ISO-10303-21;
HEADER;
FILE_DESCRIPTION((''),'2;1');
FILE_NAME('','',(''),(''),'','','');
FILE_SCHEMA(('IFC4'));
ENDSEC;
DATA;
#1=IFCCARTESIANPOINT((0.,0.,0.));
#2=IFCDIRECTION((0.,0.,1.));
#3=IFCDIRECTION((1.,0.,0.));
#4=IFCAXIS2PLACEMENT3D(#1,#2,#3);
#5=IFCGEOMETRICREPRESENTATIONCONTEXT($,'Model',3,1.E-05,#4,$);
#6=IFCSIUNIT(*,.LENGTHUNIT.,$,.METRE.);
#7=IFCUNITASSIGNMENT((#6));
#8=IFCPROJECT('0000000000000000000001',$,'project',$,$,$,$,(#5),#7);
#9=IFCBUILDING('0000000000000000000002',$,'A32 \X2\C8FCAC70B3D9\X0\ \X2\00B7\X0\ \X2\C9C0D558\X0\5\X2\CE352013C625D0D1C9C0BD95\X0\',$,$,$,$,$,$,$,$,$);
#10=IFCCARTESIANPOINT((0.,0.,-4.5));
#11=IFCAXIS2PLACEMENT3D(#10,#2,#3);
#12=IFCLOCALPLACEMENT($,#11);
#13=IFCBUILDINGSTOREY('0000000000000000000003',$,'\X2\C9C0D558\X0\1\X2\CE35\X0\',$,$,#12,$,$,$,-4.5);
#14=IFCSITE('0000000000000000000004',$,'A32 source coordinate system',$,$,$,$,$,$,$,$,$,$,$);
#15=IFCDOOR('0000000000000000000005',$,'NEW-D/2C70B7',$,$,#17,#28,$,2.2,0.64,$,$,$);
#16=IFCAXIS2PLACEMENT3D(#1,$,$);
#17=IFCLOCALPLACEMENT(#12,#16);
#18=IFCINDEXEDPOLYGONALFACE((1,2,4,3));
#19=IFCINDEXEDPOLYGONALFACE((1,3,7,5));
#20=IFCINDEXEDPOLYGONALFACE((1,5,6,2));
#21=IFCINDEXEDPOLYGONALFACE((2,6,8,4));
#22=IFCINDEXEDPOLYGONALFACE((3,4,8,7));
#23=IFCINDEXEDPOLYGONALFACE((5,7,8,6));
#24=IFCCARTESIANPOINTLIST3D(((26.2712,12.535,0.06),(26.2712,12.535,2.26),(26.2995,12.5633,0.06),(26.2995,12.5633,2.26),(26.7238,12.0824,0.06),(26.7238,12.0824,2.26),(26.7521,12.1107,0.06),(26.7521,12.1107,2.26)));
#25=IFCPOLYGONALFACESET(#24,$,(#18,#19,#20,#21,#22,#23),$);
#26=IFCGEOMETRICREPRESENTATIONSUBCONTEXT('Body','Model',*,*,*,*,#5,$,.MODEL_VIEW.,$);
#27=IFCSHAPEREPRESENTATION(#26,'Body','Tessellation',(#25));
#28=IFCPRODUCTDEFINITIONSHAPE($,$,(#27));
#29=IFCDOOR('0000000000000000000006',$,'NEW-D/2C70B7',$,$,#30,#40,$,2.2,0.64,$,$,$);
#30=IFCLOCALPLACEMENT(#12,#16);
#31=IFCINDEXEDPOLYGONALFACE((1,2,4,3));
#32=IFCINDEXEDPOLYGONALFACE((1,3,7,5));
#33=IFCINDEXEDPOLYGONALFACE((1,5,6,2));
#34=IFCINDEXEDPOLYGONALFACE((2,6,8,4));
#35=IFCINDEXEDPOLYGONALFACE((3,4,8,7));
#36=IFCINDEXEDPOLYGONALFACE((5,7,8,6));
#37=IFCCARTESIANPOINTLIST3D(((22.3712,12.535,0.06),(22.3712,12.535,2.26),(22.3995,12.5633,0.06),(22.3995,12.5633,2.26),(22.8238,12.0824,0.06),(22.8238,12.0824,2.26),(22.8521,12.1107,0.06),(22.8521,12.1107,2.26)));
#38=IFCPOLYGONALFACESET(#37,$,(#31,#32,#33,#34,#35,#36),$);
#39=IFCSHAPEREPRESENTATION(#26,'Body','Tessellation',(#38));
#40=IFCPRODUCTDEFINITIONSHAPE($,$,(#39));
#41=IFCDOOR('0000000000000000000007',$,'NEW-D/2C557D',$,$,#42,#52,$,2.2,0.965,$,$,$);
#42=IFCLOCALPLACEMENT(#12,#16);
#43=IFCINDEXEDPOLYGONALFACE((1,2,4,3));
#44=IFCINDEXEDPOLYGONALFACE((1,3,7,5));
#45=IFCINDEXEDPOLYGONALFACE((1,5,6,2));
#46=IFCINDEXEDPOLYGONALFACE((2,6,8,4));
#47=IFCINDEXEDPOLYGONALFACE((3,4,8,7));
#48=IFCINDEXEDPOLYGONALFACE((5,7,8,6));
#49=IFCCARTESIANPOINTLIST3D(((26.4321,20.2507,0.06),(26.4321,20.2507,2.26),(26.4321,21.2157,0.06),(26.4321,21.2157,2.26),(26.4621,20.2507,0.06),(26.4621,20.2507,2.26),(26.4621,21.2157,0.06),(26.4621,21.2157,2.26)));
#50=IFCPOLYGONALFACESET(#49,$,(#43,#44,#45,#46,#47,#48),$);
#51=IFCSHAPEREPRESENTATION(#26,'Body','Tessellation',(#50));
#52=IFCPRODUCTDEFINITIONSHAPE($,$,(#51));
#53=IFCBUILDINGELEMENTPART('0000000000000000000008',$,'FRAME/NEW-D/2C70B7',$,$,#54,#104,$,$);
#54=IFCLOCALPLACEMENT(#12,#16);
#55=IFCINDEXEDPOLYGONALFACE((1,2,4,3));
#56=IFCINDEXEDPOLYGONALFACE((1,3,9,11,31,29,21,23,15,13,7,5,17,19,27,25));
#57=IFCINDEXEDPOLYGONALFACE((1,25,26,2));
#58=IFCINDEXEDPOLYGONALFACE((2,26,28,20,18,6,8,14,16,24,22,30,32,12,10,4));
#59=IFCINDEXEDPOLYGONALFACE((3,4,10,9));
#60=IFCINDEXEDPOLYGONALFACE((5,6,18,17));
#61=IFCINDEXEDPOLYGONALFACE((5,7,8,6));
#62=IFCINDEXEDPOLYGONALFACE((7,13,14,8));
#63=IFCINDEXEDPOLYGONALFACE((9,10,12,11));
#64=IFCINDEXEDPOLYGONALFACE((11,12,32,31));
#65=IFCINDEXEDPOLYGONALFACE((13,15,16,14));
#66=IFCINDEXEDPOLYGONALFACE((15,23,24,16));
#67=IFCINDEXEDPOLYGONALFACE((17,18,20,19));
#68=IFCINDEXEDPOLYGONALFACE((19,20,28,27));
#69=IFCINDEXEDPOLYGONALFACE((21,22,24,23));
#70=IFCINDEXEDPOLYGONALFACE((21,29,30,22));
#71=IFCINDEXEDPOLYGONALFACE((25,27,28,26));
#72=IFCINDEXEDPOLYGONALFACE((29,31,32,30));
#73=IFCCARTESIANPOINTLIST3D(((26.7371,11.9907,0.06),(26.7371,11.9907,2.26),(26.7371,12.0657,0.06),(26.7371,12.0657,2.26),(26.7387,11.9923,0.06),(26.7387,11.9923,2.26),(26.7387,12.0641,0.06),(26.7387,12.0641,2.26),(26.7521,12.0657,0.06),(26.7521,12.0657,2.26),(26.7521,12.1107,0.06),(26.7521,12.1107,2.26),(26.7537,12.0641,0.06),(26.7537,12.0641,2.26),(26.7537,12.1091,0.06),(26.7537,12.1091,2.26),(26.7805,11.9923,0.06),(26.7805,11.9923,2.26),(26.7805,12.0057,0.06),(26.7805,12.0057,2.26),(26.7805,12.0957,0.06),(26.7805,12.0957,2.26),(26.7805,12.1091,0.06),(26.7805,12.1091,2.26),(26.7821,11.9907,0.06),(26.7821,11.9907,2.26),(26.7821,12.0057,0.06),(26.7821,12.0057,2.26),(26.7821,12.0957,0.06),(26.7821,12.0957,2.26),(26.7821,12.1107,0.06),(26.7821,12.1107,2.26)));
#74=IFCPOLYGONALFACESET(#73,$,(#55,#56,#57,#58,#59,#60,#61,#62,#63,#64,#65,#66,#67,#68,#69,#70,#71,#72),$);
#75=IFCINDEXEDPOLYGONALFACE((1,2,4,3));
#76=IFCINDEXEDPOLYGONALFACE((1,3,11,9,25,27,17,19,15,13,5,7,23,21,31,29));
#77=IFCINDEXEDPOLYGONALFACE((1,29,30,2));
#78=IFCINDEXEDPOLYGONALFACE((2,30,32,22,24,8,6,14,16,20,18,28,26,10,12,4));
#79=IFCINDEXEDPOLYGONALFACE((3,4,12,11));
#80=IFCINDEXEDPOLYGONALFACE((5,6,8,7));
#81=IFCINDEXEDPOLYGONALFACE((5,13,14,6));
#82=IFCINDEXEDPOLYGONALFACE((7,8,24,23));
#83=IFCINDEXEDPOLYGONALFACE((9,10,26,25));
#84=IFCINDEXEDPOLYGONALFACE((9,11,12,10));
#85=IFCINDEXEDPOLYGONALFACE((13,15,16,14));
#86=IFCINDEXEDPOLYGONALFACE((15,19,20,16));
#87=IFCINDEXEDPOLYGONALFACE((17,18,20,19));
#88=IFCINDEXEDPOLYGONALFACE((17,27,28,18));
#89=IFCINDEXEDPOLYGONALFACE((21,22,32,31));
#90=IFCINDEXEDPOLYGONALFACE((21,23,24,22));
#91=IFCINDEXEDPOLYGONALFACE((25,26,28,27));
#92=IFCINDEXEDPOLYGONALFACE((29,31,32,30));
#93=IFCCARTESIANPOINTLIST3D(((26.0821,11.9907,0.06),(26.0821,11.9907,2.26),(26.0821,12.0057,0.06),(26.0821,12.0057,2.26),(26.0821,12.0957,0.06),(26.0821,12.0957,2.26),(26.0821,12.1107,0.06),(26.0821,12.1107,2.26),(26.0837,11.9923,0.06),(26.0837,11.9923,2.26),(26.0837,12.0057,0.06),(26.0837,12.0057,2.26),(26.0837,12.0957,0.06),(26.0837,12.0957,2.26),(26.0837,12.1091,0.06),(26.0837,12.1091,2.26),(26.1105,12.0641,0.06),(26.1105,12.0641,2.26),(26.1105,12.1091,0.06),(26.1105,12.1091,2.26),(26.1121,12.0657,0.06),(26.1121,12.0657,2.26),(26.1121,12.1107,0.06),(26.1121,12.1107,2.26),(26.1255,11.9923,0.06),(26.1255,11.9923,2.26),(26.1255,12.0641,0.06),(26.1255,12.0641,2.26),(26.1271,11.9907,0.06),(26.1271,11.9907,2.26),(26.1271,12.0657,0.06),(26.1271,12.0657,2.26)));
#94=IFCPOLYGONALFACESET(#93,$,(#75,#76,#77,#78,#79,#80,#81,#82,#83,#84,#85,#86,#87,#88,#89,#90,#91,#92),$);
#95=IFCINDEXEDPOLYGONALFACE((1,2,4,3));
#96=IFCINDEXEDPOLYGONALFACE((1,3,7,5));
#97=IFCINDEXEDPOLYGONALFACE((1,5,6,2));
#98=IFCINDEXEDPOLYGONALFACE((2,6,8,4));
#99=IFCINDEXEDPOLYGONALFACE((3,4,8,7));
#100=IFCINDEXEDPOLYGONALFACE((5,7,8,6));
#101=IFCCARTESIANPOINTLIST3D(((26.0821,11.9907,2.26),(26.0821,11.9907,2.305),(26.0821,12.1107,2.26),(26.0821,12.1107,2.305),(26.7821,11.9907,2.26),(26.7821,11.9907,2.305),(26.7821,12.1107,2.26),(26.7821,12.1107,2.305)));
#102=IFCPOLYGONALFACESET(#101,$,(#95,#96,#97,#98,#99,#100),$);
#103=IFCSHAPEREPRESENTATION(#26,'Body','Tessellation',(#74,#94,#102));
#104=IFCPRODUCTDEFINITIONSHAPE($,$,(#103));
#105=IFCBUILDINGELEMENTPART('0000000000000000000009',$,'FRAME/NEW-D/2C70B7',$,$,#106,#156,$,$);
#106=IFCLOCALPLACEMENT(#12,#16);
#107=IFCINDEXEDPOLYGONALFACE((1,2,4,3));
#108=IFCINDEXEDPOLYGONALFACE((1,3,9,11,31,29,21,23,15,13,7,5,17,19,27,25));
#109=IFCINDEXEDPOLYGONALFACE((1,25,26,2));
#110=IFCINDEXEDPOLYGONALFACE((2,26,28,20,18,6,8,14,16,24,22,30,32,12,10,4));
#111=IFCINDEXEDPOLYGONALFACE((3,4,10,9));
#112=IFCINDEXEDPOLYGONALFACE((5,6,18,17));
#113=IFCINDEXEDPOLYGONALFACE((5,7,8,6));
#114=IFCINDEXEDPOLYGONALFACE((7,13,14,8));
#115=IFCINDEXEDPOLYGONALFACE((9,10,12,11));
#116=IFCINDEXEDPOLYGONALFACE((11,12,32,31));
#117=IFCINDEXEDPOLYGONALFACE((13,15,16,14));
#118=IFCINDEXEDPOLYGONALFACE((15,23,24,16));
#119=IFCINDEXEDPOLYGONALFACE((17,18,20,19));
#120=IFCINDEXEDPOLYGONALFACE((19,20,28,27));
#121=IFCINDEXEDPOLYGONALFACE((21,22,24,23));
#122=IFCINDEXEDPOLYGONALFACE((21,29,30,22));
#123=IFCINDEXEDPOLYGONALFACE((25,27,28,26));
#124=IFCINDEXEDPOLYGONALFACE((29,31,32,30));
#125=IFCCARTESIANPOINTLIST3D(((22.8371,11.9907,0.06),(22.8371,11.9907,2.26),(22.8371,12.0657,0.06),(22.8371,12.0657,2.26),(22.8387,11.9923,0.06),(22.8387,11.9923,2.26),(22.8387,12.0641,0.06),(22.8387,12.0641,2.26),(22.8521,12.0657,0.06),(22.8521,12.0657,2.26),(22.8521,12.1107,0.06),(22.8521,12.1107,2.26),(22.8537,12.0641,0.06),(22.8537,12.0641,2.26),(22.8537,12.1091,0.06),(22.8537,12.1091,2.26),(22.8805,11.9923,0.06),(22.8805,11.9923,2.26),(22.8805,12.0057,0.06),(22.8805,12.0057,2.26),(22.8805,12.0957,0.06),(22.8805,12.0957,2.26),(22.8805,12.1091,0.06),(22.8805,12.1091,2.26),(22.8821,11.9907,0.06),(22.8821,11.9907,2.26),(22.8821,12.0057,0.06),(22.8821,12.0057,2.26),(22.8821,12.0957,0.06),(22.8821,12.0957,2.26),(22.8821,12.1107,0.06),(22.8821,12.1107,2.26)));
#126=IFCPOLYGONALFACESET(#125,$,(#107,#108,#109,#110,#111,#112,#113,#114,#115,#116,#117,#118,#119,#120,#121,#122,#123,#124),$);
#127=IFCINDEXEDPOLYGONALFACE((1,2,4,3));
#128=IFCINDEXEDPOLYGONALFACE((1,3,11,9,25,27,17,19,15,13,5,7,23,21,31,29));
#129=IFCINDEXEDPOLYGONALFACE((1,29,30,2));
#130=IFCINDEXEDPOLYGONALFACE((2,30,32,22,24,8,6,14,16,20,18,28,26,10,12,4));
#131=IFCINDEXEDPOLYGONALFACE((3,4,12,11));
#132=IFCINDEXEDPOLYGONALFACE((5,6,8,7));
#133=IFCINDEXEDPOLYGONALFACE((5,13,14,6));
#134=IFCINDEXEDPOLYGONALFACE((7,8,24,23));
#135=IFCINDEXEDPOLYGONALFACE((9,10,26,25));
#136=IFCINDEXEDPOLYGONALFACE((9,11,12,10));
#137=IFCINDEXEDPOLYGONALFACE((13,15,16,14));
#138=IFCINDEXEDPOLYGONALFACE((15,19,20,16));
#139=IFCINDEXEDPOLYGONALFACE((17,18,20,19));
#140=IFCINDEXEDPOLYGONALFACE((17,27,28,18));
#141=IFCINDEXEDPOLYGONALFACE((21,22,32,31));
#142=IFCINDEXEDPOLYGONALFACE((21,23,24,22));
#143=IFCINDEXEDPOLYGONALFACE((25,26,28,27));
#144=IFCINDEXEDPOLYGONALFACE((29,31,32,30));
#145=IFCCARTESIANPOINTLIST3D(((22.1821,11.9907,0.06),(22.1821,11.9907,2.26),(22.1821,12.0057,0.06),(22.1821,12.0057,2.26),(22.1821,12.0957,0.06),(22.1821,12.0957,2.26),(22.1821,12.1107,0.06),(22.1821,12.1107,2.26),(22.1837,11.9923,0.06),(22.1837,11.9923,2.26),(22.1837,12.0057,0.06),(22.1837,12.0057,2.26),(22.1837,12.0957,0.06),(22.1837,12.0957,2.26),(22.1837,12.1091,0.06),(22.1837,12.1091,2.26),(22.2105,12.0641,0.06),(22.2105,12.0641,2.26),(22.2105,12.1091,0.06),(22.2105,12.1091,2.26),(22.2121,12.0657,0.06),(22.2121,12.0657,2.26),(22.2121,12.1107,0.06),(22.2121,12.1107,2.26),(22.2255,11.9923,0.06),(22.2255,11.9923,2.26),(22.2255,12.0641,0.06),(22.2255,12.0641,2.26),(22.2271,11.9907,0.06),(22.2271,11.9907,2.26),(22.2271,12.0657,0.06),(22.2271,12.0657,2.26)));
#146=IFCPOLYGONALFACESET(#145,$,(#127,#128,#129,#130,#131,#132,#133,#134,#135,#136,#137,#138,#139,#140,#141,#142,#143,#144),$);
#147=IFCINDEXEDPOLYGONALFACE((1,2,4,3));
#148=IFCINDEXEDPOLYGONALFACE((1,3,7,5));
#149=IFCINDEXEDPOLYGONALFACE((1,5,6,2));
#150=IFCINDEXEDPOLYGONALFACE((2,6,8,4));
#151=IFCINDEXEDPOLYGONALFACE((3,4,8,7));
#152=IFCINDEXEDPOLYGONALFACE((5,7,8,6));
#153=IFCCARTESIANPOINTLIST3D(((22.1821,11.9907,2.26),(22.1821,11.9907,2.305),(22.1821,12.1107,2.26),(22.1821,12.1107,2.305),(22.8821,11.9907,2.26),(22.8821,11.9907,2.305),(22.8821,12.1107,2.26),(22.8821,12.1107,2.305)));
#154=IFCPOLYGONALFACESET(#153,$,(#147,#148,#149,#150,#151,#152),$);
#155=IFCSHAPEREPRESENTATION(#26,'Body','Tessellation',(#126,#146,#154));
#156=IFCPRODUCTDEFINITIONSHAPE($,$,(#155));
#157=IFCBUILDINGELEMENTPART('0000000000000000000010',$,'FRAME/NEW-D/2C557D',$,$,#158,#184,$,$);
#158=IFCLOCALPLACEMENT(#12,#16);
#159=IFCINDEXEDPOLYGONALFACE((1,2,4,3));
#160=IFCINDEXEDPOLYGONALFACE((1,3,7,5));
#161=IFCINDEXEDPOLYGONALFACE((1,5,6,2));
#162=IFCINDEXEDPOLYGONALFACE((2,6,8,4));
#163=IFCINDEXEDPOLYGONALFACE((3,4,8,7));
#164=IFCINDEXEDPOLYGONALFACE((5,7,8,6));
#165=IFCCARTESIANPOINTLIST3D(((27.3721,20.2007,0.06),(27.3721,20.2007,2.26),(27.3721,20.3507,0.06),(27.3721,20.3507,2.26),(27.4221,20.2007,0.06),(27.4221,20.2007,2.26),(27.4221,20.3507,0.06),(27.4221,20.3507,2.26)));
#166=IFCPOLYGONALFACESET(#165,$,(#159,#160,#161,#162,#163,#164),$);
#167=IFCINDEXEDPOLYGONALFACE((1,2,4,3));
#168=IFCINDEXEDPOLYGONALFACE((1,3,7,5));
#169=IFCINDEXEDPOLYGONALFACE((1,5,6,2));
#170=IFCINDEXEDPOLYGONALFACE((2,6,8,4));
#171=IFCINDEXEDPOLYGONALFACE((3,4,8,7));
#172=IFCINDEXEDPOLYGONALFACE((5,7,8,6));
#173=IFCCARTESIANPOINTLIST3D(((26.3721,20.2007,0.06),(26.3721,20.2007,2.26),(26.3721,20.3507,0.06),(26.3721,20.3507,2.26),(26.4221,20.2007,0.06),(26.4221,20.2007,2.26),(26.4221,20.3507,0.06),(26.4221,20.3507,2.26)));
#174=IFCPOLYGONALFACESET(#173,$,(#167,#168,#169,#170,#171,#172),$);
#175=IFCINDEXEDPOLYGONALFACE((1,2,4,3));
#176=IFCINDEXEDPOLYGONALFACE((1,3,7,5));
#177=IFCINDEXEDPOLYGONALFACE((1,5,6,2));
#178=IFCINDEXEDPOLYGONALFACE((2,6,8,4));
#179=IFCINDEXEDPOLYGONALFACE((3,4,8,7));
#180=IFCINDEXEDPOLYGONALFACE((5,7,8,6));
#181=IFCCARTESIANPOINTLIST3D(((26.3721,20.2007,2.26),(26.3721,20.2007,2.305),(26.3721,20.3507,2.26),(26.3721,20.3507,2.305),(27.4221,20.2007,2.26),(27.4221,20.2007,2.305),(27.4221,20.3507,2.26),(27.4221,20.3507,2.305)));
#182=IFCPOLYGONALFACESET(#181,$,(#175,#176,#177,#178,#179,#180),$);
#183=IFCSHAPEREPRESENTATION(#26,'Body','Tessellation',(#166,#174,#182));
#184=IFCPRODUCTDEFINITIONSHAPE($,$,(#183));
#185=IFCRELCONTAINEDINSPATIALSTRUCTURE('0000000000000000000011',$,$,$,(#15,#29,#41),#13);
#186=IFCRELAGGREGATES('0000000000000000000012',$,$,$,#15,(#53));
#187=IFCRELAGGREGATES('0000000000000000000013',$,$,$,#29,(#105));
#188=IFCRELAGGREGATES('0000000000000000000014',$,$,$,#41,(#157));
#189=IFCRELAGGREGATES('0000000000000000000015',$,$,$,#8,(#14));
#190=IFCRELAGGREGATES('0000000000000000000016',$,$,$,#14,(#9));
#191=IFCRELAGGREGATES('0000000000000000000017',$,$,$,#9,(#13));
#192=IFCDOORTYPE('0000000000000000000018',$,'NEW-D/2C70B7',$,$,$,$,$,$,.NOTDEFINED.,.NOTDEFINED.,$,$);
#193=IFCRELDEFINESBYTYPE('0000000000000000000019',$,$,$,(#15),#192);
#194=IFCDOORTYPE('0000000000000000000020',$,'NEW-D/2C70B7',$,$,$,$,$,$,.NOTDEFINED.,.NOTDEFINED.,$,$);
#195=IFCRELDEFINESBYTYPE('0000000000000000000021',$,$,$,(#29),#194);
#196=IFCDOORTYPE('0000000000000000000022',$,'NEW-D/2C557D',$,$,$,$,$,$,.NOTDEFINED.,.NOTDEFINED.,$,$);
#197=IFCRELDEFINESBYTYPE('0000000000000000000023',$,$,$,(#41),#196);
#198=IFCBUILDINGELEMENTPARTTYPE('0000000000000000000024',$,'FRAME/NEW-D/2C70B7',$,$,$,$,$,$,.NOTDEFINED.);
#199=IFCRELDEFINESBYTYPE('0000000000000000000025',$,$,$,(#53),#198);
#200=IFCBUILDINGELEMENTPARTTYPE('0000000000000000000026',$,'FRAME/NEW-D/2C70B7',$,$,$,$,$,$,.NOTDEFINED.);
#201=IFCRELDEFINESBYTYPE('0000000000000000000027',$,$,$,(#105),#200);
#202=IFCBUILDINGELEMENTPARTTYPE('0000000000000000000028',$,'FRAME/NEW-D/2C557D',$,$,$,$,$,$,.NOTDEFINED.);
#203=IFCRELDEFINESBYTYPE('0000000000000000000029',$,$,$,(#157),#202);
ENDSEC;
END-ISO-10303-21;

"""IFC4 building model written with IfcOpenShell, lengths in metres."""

from ifc_helpers import new_model, si_unit, frame, origin, origin_with_axes, place, context, subcontext, project, spatial, polyline, outline, extrude, source, transform, mapped, type_object, type_shapes, element, aggregate, save


model = new_model("IFC4")

# Units and contexts
model_context = context("Model", 3, precision=1e-05, world=origin_with_axes())
body_context = subcontext(model_context, "Body", "Model", "MODEL_VIEW")
ifc_project = project(units=[si_unit("LENGTHUNIT", "METRE")], contexts=[model_context])

# Site, building, storey
site = spatial("IfcSite", under=ifc_project, Name="A32 source coordinate system")
building = spatial("IfcBuilding", under=site, Name="A32 주거동 · 지하5층–옥탑지붕")
storey_placement = place(None, frame((0.0, 0.0, -4.5), z_axis=(0.0, 0.0, 1.0), x_axis=(1.0, 0.0, 0.0)))
storey = spatial("IfcBuildingStorey", under=building, at=storey_placement, Name="지하1층", Elevation=-4.5)

# Doors
door_type_1 = type_object("IfcDoorType", Name="NEW-D/2C70B7", OperationType="NOTDEFINED", PredefinedType="NOTDEFINED")
shared_shape_1 = source(origin(), body_context, "Body", "SweptSolid", [
    extrude(outline(polyline([(26.7521, 12.1107), (26.7238, 12.0824), (26.2712, 12.535), (26.2995, 12.5633), (26.7521, 12.1107)])), frame((0.0, 0.0, 0.06)), (0.0, 0.0, 1.0), 2.2),
])
type_shapes(door_type_1, [shared_shape_1])
door_1_placement = place(storey_placement, origin_with_axes())
door_1 = element("IfcDoor", 1, at=door_1_placement, inside=storey, type_object=door_type_1, Name="NEW-D/2C70B7", OverallHeight=2.2, OverallWidth=0.64, context=body_context, shape_type="MappedRepresentation", body=[
    mapped(shared_shape_1, transform((0.0, 0.0, 0.0), scale=1.0)),
])
door_type_2 = type_object("IfcDoorType", Name="NEW-D/2C70B7", OperationType="NOTDEFINED", PredefinedType="NOTDEFINED")
shared_shape_2 = source(origin(), body_context, "Body", "SweptSolid", [
    extrude(outline(polyline([(22.8521, 12.1107), (22.8238, 12.0824), (22.3712, 12.535), (22.3995, 12.5633), (22.8521, 12.1107)])), frame((0.0, 0.0, 0.06)), (0.0, 0.0, 1.0), 2.2),
])
type_shapes(door_type_2, [shared_shape_2])
door_2_placement = place(storey_placement, origin_with_axes())
door_2 = element("IfcDoor", 2, at=door_2_placement, inside=storey, type_object=door_type_2, Name="NEW-D/2C70B7", OverallHeight=2.2, OverallWidth=0.64, context=body_context, shape_type="MappedRepresentation", body=[
    mapped(shared_shape_2, transform((0.0, 0.0, 0.0), scale=1.0)),
])
door_type_3 = type_object("IfcDoorType", Name="NEW-D/2C557D", OperationType="NOTDEFINED", PredefinedType="NOTDEFINED")
shared_shape_3 = source(origin(), body_context, "Body", "SweptSolid", [
    extrude(outline(polyline([(26.4321, 21.2157), (26.4621, 21.2157), (26.4621, 20.2507), (26.4321, 20.2507), (26.4321, 21.2157)])), frame((0.0, 0.0, 0.06)), (0.0, 0.0, 1.0), 2.2),
])
type_shapes(door_type_3, [shared_shape_3])
door_3_placement = place(storey_placement, origin_with_axes())
door_3 = element("IfcDoor", 3, at=door_3_placement, inside=storey, type_object=door_type_3, Name="NEW-D/2C557D", OverallHeight=2.2, OverallWidth=0.965, context=body_context, shape_type="MappedRepresentation", body=[
    mapped(shared_shape_3, transform((0.0, 0.0, 0.0), scale=1.0)),
])

# Building element parts
building_element_part_type_1 = type_object("IfcBuildingElementPartType", Name="FRAME/NEW-D/2C70B7", PredefinedType="NOTDEFINED")
shared_shape_4 = source(origin(), body_context, "Body", "SweptSolid", [
    extrude(outline(polyline([(26.7537, 12.1091), (26.7537, 12.0641), (26.7387, 12.0641), (26.7387, 11.9923), (26.7805, 11.9923), (26.7805, 12.0057), (26.7821, 12.0057), (26.7821, 11.9907), (26.7371, 11.9907), (26.7371, 12.0657), (26.7521, 12.0657), (26.7521, 12.1107), (26.7821, 12.1107), (26.7821, 12.0957), (26.7805, 12.0957), (26.7805, 12.1091), (26.7537, 12.1091)])), frame((0.0, 0.0, 0.06)), (0.0, 0.0, 1.0), 2.2),
    extrude(outline(polyline([(26.0821, 12.1107), (26.1121, 12.1107), (26.1121, 12.0657), (26.1271, 12.0657), (26.1271, 11.9907), (26.0821, 11.9907), (26.0821, 12.0057), (26.0837, 12.0057), (26.0837, 11.9923), (26.1255, 11.9923), (26.1255, 12.0641), (26.1105, 12.0641), (26.1105, 12.1091), (26.0837, 12.1091), (26.0837, 12.0957), (26.0821, 12.0957), (26.0821, 12.1107)])), frame((0.0, 0.0, 0.06)), (0.0, 0.0, 1.0), 2.2),
    extrude(outline(polyline([(26.7821, 11.9907), (26.7821, 12.1107), (26.0821, 12.1107), (26.0821, 11.9907), (26.7821, 11.9907)])), frame((0.0, 0.0, 2.26)), (0.0, 0.0, 1.0), 0.045),
])
type_shapes(building_element_part_type_1, [shared_shape_4])
building_element_part_1_placement = place(door_1_placement, origin_with_axes())
building_element_part_1 = element("IfcBuildingElementPart", 4, at=building_element_part_1_placement, type_object=building_element_part_type_1, Name="FRAME/NEW-D/2C70B7", context=body_context, shape_type="MappedRepresentation", body=[
    mapped(shared_shape_4, transform((0.0, 0.0, 0.0), scale=1.0)),
])
aggregate(door_1, [building_element_part_1])
building_element_part_type_2 = type_object("IfcBuildingElementPartType", Name="FRAME/NEW-D/2C70B7", PredefinedType="NOTDEFINED")
shared_shape_5 = source(origin(), body_context, "Body", "SweptSolid", [
    extrude(outline(polyline([(22.8537, 12.1091), (22.8537, 12.0641), (22.8387, 12.0641), (22.8387, 11.9923), (22.8805, 11.9923), (22.8805, 12.0057), (22.8821, 12.0057), (22.8821, 11.9907), (22.8371, 11.9907), (22.8371, 12.0657), (22.8521, 12.0657), (22.8521, 12.1107), (22.8821, 12.1107), (22.8821, 12.0957), (22.8805, 12.0957), (22.8805, 12.1091), (22.8537, 12.1091)])), frame((0.0, 0.0, 0.06)), (0.0, 0.0, 1.0), 2.2),
    extrude(outline(polyline([(22.1821, 12.1107), (22.2121, 12.1107), (22.2121, 12.0657), (22.2271, 12.0657), (22.2271, 11.9907), (22.1821, 11.9907), (22.1821, 12.0057), (22.1837, 12.0057), (22.1837, 11.9923), (22.2255, 11.9923), (22.2255, 12.0641), (22.2105, 12.0641), (22.2105, 12.1091), (22.1837, 12.1091), (22.1837, 12.0957), (22.1821, 12.0957), (22.1821, 12.1107)])), frame((0.0, 0.0, 0.06)), (0.0, 0.0, 1.0), 2.2),
    extrude(outline(polyline([(22.8821, 11.9907), (22.8821, 12.1107), (22.1821, 12.1107), (22.1821, 11.9907), (22.8821, 11.9907)])), frame((0.0, 0.0, 2.26)), (0.0, 0.0, 1.0), 0.045),
])
type_shapes(building_element_part_type_2, [shared_shape_5])
building_element_part_2_placement = place(door_2_placement, origin_with_axes())
building_element_part_2 = element("IfcBuildingElementPart", 5, at=building_element_part_2_placement, type_object=building_element_part_type_2, Name="FRAME/NEW-D/2C70B7", context=body_context, shape_type="MappedRepresentation", body=[
    mapped(shared_shape_5, transform((0.0, 0.0, 0.0), scale=1.0)),
])
aggregate(door_2, [building_element_part_2])
building_element_part_type_3 = type_object("IfcBuildingElementPartType", Name="FRAME/NEW-D/2C557D", PredefinedType="NOTDEFINED")
shared_shape_6 = source(origin(), body_context, "Body", "SweptSolid", [
    extrude(outline(polyline([(27.4221, 20.2007), (27.3721, 20.2007), (27.3721, 20.3507), (27.4221, 20.3507), (27.4221, 20.2007)])), frame((0.0, 0.0, 0.06)), (0.0, 0.0, 1.0), 2.2),
    extrude(outline(polyline([(26.4221, 20.2007), (26.3721, 20.2007), (26.3721, 20.3507), (26.4221, 20.3507), (26.4221, 20.2007)])), frame((0.0, 0.0, 0.06)), (0.0, 0.0, 1.0), 2.2),
    extrude(outline(polyline([(27.4221, 20.2007), (27.4221, 20.3507), (26.3721, 20.3507), (26.3721, 20.2007), (27.4221, 20.2007)])), frame((0.0, 0.0, 2.26)), (0.0, 0.0, 1.0), 0.045),
])
type_shapes(building_element_part_type_3, [shared_shape_6])
building_element_part_3_placement = place(door_3_placement, origin_with_axes())
building_element_part_3 = element("IfcBuildingElementPart", 6, at=building_element_part_3_placement, type_object=building_element_part_type_3, Name="FRAME/NEW-D/2C557D", context=body_context, shape_type="MappedRepresentation", body=[
    mapped(shared_shape_6, transform((0.0, 0.0, 0.0), scale=1.0)),
])
aggregate(door_3, [building_element_part_3])

save(model, "model.ifc")
